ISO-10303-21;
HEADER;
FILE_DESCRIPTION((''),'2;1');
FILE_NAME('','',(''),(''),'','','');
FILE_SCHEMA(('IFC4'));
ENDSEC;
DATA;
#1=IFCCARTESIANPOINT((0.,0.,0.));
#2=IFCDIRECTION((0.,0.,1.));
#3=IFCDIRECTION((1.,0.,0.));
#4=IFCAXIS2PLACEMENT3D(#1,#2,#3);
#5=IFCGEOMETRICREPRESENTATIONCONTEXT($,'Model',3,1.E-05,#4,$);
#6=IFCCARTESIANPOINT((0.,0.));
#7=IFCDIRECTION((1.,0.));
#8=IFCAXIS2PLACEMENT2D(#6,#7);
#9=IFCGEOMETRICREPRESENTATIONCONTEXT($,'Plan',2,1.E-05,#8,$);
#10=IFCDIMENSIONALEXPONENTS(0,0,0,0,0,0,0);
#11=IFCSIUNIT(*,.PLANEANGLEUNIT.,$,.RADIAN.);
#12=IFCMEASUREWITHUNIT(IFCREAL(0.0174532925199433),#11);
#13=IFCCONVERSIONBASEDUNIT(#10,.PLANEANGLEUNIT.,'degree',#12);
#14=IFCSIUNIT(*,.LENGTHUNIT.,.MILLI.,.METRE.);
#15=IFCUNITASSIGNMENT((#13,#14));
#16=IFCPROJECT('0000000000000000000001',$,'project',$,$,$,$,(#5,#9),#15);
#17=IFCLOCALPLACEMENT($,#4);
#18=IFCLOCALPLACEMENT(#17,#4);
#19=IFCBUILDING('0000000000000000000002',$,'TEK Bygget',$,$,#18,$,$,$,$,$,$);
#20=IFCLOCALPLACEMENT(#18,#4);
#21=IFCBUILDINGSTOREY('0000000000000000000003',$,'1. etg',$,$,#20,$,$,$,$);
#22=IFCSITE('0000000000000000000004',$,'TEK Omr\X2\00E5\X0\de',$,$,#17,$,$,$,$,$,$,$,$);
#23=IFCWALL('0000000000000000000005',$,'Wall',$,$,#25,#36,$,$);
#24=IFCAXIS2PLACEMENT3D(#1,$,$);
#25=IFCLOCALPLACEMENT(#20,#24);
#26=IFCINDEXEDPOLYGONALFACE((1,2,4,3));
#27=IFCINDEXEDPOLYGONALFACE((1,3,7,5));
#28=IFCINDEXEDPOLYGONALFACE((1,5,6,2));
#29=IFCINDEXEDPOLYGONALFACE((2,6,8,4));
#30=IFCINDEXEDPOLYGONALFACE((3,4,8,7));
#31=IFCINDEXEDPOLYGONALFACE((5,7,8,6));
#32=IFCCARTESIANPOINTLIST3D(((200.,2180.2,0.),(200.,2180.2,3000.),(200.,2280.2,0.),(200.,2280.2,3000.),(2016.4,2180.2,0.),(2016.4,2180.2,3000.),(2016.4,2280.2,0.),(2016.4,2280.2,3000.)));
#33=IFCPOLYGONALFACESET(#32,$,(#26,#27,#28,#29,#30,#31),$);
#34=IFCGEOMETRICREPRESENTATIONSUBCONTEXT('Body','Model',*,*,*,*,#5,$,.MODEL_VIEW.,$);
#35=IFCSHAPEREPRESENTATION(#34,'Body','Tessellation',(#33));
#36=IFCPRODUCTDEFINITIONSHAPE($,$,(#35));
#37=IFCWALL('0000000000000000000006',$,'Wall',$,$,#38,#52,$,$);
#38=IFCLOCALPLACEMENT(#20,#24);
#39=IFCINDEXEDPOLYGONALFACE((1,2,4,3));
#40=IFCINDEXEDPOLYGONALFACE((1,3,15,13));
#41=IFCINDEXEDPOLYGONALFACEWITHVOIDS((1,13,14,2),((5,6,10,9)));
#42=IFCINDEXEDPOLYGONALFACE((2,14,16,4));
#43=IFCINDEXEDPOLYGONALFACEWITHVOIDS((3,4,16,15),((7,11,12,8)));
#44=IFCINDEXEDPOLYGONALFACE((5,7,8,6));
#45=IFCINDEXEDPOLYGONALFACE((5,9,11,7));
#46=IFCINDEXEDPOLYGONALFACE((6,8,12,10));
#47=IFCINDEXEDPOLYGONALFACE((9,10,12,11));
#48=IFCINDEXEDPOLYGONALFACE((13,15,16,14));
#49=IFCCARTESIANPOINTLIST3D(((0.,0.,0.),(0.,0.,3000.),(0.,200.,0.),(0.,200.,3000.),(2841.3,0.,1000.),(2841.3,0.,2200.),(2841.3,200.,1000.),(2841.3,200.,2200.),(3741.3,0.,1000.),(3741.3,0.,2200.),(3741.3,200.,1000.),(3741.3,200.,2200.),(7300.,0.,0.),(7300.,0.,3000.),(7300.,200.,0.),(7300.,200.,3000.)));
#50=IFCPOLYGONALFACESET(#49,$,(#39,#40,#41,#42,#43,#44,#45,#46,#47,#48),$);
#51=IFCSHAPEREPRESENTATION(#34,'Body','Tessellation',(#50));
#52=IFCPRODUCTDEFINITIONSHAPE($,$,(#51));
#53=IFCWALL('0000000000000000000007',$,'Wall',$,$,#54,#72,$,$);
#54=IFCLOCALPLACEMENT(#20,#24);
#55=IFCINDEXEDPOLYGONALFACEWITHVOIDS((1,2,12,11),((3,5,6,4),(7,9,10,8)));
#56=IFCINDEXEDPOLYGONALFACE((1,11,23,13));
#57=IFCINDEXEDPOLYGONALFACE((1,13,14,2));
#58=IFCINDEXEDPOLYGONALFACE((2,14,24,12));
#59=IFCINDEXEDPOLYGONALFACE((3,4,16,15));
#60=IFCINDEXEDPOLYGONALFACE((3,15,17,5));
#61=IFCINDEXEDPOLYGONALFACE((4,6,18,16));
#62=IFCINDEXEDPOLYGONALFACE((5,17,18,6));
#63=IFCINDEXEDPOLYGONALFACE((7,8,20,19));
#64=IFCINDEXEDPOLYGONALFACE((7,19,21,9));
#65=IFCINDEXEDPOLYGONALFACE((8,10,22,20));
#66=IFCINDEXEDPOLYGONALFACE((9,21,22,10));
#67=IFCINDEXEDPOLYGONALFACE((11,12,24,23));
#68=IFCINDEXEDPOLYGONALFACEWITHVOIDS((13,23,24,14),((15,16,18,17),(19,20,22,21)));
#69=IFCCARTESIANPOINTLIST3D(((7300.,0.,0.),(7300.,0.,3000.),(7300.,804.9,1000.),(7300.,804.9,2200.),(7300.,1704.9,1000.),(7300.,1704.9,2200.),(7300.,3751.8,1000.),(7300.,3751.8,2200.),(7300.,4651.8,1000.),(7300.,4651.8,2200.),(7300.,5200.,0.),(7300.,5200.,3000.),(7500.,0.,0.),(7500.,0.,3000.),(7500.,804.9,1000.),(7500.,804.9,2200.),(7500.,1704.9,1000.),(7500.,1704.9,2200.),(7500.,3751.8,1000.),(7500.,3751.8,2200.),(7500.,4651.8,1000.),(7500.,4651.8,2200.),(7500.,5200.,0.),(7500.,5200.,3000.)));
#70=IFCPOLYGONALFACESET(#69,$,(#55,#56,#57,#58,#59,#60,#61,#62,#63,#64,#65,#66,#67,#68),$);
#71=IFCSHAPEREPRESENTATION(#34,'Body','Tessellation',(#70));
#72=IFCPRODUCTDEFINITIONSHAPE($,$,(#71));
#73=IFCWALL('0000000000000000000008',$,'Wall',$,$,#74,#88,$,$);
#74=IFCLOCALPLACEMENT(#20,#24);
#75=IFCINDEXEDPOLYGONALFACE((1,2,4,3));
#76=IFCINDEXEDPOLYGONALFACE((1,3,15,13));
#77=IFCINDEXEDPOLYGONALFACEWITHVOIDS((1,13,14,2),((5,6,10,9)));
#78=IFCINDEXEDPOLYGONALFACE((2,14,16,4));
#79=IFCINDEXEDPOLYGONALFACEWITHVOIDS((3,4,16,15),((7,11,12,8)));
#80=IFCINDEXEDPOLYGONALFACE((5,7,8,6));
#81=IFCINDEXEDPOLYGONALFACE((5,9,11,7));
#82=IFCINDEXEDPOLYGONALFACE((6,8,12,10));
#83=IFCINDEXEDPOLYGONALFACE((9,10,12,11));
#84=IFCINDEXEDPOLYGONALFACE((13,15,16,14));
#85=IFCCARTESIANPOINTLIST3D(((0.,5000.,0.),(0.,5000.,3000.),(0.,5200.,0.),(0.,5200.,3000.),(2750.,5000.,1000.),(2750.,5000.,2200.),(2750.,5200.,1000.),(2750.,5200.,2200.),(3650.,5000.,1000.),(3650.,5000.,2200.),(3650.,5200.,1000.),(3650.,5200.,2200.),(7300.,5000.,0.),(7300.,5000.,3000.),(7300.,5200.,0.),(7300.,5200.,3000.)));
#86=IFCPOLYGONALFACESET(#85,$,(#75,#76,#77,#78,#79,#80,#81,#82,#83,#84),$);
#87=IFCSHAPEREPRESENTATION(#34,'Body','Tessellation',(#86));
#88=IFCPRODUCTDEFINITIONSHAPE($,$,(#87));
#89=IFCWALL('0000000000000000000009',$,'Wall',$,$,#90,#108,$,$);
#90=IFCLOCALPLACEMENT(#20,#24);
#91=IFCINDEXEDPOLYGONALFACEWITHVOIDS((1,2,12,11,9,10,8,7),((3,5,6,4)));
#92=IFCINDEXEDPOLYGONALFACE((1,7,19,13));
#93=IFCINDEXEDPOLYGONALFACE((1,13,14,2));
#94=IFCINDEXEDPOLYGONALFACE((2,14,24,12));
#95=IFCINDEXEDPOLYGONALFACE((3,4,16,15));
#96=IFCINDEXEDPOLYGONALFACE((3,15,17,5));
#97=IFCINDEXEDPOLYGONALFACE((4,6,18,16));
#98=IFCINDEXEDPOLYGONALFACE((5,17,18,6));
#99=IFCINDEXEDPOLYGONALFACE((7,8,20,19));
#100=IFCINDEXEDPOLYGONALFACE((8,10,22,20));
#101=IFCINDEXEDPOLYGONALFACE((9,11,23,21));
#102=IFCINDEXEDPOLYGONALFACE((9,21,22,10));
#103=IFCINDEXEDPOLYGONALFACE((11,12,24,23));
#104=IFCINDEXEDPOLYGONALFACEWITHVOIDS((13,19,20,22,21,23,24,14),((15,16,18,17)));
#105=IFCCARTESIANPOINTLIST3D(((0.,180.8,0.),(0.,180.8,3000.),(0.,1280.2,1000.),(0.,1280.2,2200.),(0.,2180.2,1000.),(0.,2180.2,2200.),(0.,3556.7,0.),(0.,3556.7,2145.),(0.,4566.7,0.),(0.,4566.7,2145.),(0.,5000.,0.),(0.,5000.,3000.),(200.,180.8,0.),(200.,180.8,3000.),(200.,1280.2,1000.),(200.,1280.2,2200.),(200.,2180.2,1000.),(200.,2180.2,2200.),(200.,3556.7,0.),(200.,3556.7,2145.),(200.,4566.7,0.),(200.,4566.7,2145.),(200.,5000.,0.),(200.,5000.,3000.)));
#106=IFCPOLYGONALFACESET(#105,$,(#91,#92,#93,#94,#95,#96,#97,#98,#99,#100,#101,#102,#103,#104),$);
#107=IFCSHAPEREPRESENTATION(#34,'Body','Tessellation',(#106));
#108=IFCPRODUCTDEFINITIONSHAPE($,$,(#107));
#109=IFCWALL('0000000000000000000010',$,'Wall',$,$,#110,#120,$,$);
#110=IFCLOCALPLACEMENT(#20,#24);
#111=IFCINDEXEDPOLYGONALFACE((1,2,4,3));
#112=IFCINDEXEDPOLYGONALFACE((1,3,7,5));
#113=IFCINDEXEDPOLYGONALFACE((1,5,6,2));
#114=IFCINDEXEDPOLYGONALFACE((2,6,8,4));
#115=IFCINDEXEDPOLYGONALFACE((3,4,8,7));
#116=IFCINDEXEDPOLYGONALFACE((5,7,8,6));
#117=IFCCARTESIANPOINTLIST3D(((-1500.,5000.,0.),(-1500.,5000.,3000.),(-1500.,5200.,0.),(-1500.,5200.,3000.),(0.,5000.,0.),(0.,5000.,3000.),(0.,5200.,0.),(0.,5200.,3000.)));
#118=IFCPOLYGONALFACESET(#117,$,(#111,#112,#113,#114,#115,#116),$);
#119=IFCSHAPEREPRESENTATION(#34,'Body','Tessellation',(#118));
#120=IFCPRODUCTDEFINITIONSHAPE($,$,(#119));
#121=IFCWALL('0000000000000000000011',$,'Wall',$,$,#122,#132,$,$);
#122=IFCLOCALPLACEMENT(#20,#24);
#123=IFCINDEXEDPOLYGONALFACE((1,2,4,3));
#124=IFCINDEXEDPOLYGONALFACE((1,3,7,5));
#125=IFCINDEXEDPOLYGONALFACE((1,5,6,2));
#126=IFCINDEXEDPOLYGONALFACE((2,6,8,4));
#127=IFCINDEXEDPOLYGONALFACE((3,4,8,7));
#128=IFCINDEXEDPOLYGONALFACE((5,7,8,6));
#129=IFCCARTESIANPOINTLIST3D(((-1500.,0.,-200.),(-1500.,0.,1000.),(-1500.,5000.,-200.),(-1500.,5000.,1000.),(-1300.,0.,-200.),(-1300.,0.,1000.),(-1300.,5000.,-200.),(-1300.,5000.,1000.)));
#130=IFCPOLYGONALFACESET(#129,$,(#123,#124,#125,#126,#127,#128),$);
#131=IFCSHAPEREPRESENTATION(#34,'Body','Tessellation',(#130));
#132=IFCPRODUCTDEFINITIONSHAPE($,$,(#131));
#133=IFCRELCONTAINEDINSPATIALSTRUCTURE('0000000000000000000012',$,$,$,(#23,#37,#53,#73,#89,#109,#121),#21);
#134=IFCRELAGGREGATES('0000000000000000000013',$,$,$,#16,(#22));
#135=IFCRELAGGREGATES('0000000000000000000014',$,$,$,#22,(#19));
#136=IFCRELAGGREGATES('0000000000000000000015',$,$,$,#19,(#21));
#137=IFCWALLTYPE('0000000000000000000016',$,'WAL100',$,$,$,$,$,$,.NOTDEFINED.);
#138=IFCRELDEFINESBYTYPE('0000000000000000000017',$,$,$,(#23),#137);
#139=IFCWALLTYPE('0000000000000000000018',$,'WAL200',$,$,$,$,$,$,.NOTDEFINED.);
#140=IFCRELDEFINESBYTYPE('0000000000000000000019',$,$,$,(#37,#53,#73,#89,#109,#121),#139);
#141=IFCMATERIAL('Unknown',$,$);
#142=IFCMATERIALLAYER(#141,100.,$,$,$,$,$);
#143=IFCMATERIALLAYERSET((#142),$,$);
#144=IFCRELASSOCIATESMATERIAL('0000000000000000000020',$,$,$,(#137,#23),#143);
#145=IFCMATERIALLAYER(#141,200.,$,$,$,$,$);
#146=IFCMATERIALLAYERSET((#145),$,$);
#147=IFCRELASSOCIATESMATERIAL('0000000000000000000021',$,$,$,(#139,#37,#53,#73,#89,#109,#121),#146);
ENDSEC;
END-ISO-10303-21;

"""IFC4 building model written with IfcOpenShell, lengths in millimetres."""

from ifc_helpers import new_model, entity, si_unit, converted_unit, frame, origin_with_axes, origin_2d_with_axis, place, context, subcontext, project, spatial, line, indexed_curve, outline, extrude, source, transform, mapped, material, layer, layer_set, layer_usage, type_object, element, save


model = new_model("IFC4")

# Units and contexts
model_context = context("Model", 3, precision=1e-05, world=origin_with_axes())
plan_context = context("Plan", 2, precision=1e-05, world=origin_2d_with_axis())
body_context = subcontext(model_context, "Body", "Model", "MODEL_VIEW")
ifc_project = project(units=[converted_unit("PLANEANGLEUNIT", "degree", entity("IfcReal", 0.0174532925199433), si_unit("PLANEANGLEUNIT", "RADIAN"), dimensions=[0, 0, 0, 0, 0, 0, 0]), si_unit("LENGTHUNIT", "METRE", prefix="MILLI")], contexts=[model_context, plan_context])

# Site, building, storey
site_placement = place(None, origin_with_axes())
site = spatial("IfcSite", under=ifc_project, at=site_placement, Name="TEK Område")
building_placement = place(site_placement, origin_with_axes())
building = spatial("IfcBuilding", under=site, at=building_placement, Name="TEK Bygget")
storey_placement = place(building_placement, origin_with_axes())
storey = spatial("IfcBuildingStorey", under=building, at=storey_placement, Name="1. etg")

# Shared definitions
ifc_material = material(Name="Unknown")

# Shared definitions
ifc_layer_1 = layer(ifc_material, 100.0)
ifc_layer_set_1 = layer_set([ifc_layer_1])
wall_type_1 = type_object("IfcWallType", Name="WAL100", PredefinedType="NOTDEFINED", material=ifc_layer_set_1)
shared_shape_1 = source(origin_with_axes(), body_context, "Body", "SweptSolid", [
    extrude(outline(indexed_curve([(0.0, 0.0), (1010.0, 0.0), (1010.0, 2145.0), (0.0, 2145.0)], segments=[line(1, 2), line(2, 3), line(3, 4), line(4, 1)])), frame((0.0, -100.0, 0.0), z_axis=(0.0, -1.0, 0.0), x_axis=(1.0, 0.0, 0.0)), (0.0, 0.0, -1.0), 400.0),
])

# Wall
ifc_layer_usage_1 = layer_usage(ifc_layer_set_1, "AXIS2", "POSITIVE", 0.0)
wall_1_placement = place(storey_placement, frame((200.0, 2180.2, 0.0), z_axis=(0.0, 0.0, 1.0), x_axis=(1.0, 0.0, 0.0)))
element("IfcWall", 1, at=wall_1_placement, inside=storey, type_object=wall_type_1, material=ifc_layer_usage_1, Name="Wall", context=body_context, shape_type="SweptSolid", body=[
    extrude(outline(indexed_curve([(0.0, 0.0), (0.0, 100.0), (1816.4, 100.0), (1816.4, 0.0), (0.0, 0.0)], self_intersect=False)), origin_with_axes(), (0.0, 0.0, 1.0), 3000.0),
])

# Wall, opening
ifc_layer_2 = layer(ifc_material, 200.0)
ifc_layer_set_2 = layer_set([ifc_layer_2])
ifc_layer_usage_2 = layer_usage(ifc_layer_set_2, "AXIS2", "POSITIVE", 0.0)
wall_type_2 = type_object("IfcWallType", Name="WAL200", PredefinedType="NOTDEFINED", material=ifc_layer_set_2)
wall_2_placement = place(storey_placement, origin_with_axes())
wall_2 = element("IfcWall", 2, at=wall_2_placement, inside=storey, type_object=wall_type_2, material=ifc_layer_usage_2, Name="Wall", context=body_context, shape_type="SweptSolid", body=[
    extrude(outline(indexed_curve([(0.0, 0.0), (0.0, 200.0), (7300.0, 200.0), (7300.0, 0.0), (0.0, 0.0)], self_intersect=False)), origin_with_axes(), (0.0, 0.0, 1.0), 3000.0),
])
shared_shape_2 = source(origin_with_axes(), body_context, "Body", "SweptSolid", [
    extrude(outline(indexed_curve([(0.0, 0.0), (900.0, 0.0), (900.0, 1200.0), (0.0, 1200.0)], segments=[line(1, 2), line(2, 3), line(3, 4), line(4, 1)])), frame((0.0, -100.0, 0.0), z_axis=(0.0, -1.0, 0.0), x_axis=(1.0, 0.0, 0.0)), (0.0, 0.0, -1.0), 400.0),
])
opening_1_placement = place(wall_2_placement, frame((2841.3, 0.0, 1000.0), z_axis=(0.0, 0.0, 1.0), x_axis=(1.0, 0.0, 0.0)))
element("IfcOpeningElement", 3, at=opening_1_placement, cuts=wall_2, PredefinedType="OPENING", context=body_context, shape_type="MappedRepresentation", body=[
    mapped(shared_shape_2, transform((0.0, 0.0, 0.0), x_axis=(1.0, 0.0, 0.0), y_axis=(0.0, 1.0, 0.0), z_axis=(0.0, 0.0, 1.0), scale=1.0)),
])

# Wall, openings
ifc_layer_usage_3 = layer_usage(ifc_layer_set_2, "AXIS2", "POSITIVE", 0.0)
wall_3_placement = place(storey_placement, frame((7500.0, 0.0, 0.0), z_axis=(0.0, 0.0, 1.0), x_axis=(0.0, 1.0, 0.0)))
wall_3 = element("IfcWall", 4, at=wall_3_placement, inside=storey, type_object=wall_type_2, material=ifc_layer_usage_3, Name="Wall", context=body_context, shape_type="SweptSolid", body=[
    extrude(outline(indexed_curve([(0.0, 0.0), (0.0, 200.0), (5200.0, 200.0), (5200.0, 0.0), (0.0, 0.0)], self_intersect=False)), origin_with_axes(), (0.0, 0.0, 1.0), 3000.0),
])
opening_2_placement = place(wall_3_placement, frame((3751.8, 0.0, 1000.0), z_axis=(0.0, 0.0, 1.0), x_axis=(1.0, 0.0, 0.0)))
element("IfcOpeningElement", 5, at=opening_2_placement, cuts=wall_3, PredefinedType="OPENING", context=body_context, shape_type="MappedRepresentation", body=[
    mapped(shared_shape_2, transform((0.0, 0.0, 0.0), x_axis=(1.0, 0.0, 0.0), y_axis=(0.0, 1.0, 0.0), z_axis=(0.0, 0.0, 1.0), scale=1.0)),
])
opening_3_placement = place(wall_3_placement, frame((804.9, 0.0, 1000.0), z_axis=(0.0, 0.0, 1.0), x_axis=(1.0, 0.0, 0.0)))
element("IfcOpeningElement", 6, at=opening_3_placement, cuts=wall_3, PredefinedType="OPENING", context=body_context, shape_type="MappedRepresentation", body=[
    mapped(shared_shape_2, transform((0.0, 0.0, 0.0), x_axis=(1.0, 0.0, 0.0), y_axis=(0.0, 1.0, 0.0), z_axis=(0.0, 0.0, 1.0), scale=1.0)),
])

# Wall, opening
ifc_layer_usage_4 = layer_usage(ifc_layer_set_2, "AXIS2", "POSITIVE", 0.0)
wall_4_placement = place(storey_placement, frame((7300.0, 5200.0, 0.0), z_axis=(0.0, 0.0, 1.0), x_axis=(-1.0, 0.0, 0.0)))
wall_4 = element("IfcWall", 7, at=wall_4_placement, inside=storey, type_object=wall_type_2, material=ifc_layer_usage_4, Name="Wall", context=body_context, shape_type="SweptSolid", body=[
    extrude(outline(indexed_curve([(0.0, 0.0), (0.0, 200.0), (7300.0, 200.0), (7300.0, 0.0), (0.0, 0.0)], self_intersect=False)), origin_with_axes(), (0.0, 0.0, 1.0), 3000.0),
])
opening_4_placement = place(wall_4_placement, frame((3650.0, 0.0, 1000.0), z_axis=(0.0, 0.0, 1.0), x_axis=(1.0, 0.0, 0.0)))
element("IfcOpeningElement", 8, at=opening_4_placement, cuts=wall_4, PredefinedType="OPENING", context=body_context, shape_type="MappedRepresentation", body=[
    mapped(shared_shape_2, transform((0.0, 0.0, 0.0), x_axis=(1.0, 0.0, 0.0), y_axis=(0.0, 1.0, 0.0), z_axis=(0.0, 0.0, 1.0), scale=1.0)),
])

# Wall, openings
ifc_layer_usage_5 = layer_usage(ifc_layer_set_2, "AXIS2", "POSITIVE", 0.0)
wall_5_placement = place(storey_placement, frame((0.0, 5000.0, 0.0), z_axis=(0.0, 0.0, 1.0), x_axis=(0.0, -1.0, 0.0)))
wall_5 = element("IfcWall", 9, at=wall_5_placement, inside=storey, type_object=wall_type_2, material=ifc_layer_usage_5, Name="Wall", context=body_context, shape_type="SweptSolid", body=[
    extrude(outline(indexed_curve([(0.0, 0.0), (0.0, 200.0), (4819.2, 200.0), (4819.2, 0.0), (0.0, 0.0)], self_intersect=False)), origin_with_axes(), (0.0, 0.0, 1.0), 3000.0),
])
opening_5_placement = place(wall_5_placement, frame((433.4, 0.0, 0.0), z_axis=(0.0, 0.0, 1.0), x_axis=(1.0, 0.0, 0.0)))
element("IfcOpeningElement", 10, at=opening_5_placement, cuts=wall_5, PredefinedType="OPENING", context=body_context, shape_type="MappedRepresentation", body=[
    mapped(shared_shape_1, transform((0.0, 0.0, 0.0), x_axis=(1.0, 0.0, 0.0), y_axis=(0.0, 1.0, 0.0), z_axis=(0.0, 0.0, 1.0), scale=1.0)),
])
opening_6_placement = place(wall_5_placement, frame((2819.8, 0.0, 1000.0), z_axis=(0.0, 0.0, 1.0), x_axis=(1.0, 0.0, 0.0)))
element("IfcOpeningElement", 11, at=opening_6_placement, cuts=wall_5, PredefinedType="OPENING", context=body_context, shape_type="MappedRepresentation", body=[
    mapped(shared_shape_2, transform((0.0, 0.0, 0.0), x_axis=(1.0, 0.0, 0.0), y_axis=(0.0, 1.0, 0.0), z_axis=(0.0, 0.0, 1.0), scale=1.0)),
])

# Walls
ifc_layer_usage_6 = layer_usage(ifc_layer_set_2, "AXIS2", "POSITIVE", 0.0)
wall_6_placement = place(storey_placement, frame((0.0, 5200.0, 0.0), z_axis=(0.0, 0.0, 1.0), x_axis=(-1.0, 0.000001, 0.0)))
element("IfcWall", 12, at=wall_6_placement, inside=storey, type_object=wall_type_2, material=ifc_layer_usage_6, Name="Wall", context=body_context, shape_type="SweptSolid", body=[
    extrude(outline(indexed_curve([(0.0, 0.0), (0.0, 200.0), (1500.0, 200.0), (1500.0, 0.0), (0.0, 0.0)], self_intersect=False)), origin_with_axes(), (0.0, 0.0, 1.0), 3000.0),
])
ifc_layer_usage_7 = layer_usage(ifc_layer_set_2, "AXIS2", "POSITIVE", 0.0)
wall_7_placement = place(storey_placement, frame((-1500.0, 5000.0, -200.0), z_axis=(0.0, 0.0, 1.0), x_axis=(-0.000001, -1.0, 0.0)))
element("IfcWall", 13, at=wall_7_placement, inside=storey, type_object=wall_type_2, material=ifc_layer_usage_7, Name="Wall", context=body_context, shape_type="SweptSolid", body=[
    extrude(outline(indexed_curve([(0.0, 0.0), (0.0, 200.0), (5000.0, 200.0), (5000.0, 0.0), (0.0, 0.0)], self_intersect=False)), origin_with_axes(), (0.0, 0.0, 1.0), 1200.0),
])

save(model, "model.ifc")
